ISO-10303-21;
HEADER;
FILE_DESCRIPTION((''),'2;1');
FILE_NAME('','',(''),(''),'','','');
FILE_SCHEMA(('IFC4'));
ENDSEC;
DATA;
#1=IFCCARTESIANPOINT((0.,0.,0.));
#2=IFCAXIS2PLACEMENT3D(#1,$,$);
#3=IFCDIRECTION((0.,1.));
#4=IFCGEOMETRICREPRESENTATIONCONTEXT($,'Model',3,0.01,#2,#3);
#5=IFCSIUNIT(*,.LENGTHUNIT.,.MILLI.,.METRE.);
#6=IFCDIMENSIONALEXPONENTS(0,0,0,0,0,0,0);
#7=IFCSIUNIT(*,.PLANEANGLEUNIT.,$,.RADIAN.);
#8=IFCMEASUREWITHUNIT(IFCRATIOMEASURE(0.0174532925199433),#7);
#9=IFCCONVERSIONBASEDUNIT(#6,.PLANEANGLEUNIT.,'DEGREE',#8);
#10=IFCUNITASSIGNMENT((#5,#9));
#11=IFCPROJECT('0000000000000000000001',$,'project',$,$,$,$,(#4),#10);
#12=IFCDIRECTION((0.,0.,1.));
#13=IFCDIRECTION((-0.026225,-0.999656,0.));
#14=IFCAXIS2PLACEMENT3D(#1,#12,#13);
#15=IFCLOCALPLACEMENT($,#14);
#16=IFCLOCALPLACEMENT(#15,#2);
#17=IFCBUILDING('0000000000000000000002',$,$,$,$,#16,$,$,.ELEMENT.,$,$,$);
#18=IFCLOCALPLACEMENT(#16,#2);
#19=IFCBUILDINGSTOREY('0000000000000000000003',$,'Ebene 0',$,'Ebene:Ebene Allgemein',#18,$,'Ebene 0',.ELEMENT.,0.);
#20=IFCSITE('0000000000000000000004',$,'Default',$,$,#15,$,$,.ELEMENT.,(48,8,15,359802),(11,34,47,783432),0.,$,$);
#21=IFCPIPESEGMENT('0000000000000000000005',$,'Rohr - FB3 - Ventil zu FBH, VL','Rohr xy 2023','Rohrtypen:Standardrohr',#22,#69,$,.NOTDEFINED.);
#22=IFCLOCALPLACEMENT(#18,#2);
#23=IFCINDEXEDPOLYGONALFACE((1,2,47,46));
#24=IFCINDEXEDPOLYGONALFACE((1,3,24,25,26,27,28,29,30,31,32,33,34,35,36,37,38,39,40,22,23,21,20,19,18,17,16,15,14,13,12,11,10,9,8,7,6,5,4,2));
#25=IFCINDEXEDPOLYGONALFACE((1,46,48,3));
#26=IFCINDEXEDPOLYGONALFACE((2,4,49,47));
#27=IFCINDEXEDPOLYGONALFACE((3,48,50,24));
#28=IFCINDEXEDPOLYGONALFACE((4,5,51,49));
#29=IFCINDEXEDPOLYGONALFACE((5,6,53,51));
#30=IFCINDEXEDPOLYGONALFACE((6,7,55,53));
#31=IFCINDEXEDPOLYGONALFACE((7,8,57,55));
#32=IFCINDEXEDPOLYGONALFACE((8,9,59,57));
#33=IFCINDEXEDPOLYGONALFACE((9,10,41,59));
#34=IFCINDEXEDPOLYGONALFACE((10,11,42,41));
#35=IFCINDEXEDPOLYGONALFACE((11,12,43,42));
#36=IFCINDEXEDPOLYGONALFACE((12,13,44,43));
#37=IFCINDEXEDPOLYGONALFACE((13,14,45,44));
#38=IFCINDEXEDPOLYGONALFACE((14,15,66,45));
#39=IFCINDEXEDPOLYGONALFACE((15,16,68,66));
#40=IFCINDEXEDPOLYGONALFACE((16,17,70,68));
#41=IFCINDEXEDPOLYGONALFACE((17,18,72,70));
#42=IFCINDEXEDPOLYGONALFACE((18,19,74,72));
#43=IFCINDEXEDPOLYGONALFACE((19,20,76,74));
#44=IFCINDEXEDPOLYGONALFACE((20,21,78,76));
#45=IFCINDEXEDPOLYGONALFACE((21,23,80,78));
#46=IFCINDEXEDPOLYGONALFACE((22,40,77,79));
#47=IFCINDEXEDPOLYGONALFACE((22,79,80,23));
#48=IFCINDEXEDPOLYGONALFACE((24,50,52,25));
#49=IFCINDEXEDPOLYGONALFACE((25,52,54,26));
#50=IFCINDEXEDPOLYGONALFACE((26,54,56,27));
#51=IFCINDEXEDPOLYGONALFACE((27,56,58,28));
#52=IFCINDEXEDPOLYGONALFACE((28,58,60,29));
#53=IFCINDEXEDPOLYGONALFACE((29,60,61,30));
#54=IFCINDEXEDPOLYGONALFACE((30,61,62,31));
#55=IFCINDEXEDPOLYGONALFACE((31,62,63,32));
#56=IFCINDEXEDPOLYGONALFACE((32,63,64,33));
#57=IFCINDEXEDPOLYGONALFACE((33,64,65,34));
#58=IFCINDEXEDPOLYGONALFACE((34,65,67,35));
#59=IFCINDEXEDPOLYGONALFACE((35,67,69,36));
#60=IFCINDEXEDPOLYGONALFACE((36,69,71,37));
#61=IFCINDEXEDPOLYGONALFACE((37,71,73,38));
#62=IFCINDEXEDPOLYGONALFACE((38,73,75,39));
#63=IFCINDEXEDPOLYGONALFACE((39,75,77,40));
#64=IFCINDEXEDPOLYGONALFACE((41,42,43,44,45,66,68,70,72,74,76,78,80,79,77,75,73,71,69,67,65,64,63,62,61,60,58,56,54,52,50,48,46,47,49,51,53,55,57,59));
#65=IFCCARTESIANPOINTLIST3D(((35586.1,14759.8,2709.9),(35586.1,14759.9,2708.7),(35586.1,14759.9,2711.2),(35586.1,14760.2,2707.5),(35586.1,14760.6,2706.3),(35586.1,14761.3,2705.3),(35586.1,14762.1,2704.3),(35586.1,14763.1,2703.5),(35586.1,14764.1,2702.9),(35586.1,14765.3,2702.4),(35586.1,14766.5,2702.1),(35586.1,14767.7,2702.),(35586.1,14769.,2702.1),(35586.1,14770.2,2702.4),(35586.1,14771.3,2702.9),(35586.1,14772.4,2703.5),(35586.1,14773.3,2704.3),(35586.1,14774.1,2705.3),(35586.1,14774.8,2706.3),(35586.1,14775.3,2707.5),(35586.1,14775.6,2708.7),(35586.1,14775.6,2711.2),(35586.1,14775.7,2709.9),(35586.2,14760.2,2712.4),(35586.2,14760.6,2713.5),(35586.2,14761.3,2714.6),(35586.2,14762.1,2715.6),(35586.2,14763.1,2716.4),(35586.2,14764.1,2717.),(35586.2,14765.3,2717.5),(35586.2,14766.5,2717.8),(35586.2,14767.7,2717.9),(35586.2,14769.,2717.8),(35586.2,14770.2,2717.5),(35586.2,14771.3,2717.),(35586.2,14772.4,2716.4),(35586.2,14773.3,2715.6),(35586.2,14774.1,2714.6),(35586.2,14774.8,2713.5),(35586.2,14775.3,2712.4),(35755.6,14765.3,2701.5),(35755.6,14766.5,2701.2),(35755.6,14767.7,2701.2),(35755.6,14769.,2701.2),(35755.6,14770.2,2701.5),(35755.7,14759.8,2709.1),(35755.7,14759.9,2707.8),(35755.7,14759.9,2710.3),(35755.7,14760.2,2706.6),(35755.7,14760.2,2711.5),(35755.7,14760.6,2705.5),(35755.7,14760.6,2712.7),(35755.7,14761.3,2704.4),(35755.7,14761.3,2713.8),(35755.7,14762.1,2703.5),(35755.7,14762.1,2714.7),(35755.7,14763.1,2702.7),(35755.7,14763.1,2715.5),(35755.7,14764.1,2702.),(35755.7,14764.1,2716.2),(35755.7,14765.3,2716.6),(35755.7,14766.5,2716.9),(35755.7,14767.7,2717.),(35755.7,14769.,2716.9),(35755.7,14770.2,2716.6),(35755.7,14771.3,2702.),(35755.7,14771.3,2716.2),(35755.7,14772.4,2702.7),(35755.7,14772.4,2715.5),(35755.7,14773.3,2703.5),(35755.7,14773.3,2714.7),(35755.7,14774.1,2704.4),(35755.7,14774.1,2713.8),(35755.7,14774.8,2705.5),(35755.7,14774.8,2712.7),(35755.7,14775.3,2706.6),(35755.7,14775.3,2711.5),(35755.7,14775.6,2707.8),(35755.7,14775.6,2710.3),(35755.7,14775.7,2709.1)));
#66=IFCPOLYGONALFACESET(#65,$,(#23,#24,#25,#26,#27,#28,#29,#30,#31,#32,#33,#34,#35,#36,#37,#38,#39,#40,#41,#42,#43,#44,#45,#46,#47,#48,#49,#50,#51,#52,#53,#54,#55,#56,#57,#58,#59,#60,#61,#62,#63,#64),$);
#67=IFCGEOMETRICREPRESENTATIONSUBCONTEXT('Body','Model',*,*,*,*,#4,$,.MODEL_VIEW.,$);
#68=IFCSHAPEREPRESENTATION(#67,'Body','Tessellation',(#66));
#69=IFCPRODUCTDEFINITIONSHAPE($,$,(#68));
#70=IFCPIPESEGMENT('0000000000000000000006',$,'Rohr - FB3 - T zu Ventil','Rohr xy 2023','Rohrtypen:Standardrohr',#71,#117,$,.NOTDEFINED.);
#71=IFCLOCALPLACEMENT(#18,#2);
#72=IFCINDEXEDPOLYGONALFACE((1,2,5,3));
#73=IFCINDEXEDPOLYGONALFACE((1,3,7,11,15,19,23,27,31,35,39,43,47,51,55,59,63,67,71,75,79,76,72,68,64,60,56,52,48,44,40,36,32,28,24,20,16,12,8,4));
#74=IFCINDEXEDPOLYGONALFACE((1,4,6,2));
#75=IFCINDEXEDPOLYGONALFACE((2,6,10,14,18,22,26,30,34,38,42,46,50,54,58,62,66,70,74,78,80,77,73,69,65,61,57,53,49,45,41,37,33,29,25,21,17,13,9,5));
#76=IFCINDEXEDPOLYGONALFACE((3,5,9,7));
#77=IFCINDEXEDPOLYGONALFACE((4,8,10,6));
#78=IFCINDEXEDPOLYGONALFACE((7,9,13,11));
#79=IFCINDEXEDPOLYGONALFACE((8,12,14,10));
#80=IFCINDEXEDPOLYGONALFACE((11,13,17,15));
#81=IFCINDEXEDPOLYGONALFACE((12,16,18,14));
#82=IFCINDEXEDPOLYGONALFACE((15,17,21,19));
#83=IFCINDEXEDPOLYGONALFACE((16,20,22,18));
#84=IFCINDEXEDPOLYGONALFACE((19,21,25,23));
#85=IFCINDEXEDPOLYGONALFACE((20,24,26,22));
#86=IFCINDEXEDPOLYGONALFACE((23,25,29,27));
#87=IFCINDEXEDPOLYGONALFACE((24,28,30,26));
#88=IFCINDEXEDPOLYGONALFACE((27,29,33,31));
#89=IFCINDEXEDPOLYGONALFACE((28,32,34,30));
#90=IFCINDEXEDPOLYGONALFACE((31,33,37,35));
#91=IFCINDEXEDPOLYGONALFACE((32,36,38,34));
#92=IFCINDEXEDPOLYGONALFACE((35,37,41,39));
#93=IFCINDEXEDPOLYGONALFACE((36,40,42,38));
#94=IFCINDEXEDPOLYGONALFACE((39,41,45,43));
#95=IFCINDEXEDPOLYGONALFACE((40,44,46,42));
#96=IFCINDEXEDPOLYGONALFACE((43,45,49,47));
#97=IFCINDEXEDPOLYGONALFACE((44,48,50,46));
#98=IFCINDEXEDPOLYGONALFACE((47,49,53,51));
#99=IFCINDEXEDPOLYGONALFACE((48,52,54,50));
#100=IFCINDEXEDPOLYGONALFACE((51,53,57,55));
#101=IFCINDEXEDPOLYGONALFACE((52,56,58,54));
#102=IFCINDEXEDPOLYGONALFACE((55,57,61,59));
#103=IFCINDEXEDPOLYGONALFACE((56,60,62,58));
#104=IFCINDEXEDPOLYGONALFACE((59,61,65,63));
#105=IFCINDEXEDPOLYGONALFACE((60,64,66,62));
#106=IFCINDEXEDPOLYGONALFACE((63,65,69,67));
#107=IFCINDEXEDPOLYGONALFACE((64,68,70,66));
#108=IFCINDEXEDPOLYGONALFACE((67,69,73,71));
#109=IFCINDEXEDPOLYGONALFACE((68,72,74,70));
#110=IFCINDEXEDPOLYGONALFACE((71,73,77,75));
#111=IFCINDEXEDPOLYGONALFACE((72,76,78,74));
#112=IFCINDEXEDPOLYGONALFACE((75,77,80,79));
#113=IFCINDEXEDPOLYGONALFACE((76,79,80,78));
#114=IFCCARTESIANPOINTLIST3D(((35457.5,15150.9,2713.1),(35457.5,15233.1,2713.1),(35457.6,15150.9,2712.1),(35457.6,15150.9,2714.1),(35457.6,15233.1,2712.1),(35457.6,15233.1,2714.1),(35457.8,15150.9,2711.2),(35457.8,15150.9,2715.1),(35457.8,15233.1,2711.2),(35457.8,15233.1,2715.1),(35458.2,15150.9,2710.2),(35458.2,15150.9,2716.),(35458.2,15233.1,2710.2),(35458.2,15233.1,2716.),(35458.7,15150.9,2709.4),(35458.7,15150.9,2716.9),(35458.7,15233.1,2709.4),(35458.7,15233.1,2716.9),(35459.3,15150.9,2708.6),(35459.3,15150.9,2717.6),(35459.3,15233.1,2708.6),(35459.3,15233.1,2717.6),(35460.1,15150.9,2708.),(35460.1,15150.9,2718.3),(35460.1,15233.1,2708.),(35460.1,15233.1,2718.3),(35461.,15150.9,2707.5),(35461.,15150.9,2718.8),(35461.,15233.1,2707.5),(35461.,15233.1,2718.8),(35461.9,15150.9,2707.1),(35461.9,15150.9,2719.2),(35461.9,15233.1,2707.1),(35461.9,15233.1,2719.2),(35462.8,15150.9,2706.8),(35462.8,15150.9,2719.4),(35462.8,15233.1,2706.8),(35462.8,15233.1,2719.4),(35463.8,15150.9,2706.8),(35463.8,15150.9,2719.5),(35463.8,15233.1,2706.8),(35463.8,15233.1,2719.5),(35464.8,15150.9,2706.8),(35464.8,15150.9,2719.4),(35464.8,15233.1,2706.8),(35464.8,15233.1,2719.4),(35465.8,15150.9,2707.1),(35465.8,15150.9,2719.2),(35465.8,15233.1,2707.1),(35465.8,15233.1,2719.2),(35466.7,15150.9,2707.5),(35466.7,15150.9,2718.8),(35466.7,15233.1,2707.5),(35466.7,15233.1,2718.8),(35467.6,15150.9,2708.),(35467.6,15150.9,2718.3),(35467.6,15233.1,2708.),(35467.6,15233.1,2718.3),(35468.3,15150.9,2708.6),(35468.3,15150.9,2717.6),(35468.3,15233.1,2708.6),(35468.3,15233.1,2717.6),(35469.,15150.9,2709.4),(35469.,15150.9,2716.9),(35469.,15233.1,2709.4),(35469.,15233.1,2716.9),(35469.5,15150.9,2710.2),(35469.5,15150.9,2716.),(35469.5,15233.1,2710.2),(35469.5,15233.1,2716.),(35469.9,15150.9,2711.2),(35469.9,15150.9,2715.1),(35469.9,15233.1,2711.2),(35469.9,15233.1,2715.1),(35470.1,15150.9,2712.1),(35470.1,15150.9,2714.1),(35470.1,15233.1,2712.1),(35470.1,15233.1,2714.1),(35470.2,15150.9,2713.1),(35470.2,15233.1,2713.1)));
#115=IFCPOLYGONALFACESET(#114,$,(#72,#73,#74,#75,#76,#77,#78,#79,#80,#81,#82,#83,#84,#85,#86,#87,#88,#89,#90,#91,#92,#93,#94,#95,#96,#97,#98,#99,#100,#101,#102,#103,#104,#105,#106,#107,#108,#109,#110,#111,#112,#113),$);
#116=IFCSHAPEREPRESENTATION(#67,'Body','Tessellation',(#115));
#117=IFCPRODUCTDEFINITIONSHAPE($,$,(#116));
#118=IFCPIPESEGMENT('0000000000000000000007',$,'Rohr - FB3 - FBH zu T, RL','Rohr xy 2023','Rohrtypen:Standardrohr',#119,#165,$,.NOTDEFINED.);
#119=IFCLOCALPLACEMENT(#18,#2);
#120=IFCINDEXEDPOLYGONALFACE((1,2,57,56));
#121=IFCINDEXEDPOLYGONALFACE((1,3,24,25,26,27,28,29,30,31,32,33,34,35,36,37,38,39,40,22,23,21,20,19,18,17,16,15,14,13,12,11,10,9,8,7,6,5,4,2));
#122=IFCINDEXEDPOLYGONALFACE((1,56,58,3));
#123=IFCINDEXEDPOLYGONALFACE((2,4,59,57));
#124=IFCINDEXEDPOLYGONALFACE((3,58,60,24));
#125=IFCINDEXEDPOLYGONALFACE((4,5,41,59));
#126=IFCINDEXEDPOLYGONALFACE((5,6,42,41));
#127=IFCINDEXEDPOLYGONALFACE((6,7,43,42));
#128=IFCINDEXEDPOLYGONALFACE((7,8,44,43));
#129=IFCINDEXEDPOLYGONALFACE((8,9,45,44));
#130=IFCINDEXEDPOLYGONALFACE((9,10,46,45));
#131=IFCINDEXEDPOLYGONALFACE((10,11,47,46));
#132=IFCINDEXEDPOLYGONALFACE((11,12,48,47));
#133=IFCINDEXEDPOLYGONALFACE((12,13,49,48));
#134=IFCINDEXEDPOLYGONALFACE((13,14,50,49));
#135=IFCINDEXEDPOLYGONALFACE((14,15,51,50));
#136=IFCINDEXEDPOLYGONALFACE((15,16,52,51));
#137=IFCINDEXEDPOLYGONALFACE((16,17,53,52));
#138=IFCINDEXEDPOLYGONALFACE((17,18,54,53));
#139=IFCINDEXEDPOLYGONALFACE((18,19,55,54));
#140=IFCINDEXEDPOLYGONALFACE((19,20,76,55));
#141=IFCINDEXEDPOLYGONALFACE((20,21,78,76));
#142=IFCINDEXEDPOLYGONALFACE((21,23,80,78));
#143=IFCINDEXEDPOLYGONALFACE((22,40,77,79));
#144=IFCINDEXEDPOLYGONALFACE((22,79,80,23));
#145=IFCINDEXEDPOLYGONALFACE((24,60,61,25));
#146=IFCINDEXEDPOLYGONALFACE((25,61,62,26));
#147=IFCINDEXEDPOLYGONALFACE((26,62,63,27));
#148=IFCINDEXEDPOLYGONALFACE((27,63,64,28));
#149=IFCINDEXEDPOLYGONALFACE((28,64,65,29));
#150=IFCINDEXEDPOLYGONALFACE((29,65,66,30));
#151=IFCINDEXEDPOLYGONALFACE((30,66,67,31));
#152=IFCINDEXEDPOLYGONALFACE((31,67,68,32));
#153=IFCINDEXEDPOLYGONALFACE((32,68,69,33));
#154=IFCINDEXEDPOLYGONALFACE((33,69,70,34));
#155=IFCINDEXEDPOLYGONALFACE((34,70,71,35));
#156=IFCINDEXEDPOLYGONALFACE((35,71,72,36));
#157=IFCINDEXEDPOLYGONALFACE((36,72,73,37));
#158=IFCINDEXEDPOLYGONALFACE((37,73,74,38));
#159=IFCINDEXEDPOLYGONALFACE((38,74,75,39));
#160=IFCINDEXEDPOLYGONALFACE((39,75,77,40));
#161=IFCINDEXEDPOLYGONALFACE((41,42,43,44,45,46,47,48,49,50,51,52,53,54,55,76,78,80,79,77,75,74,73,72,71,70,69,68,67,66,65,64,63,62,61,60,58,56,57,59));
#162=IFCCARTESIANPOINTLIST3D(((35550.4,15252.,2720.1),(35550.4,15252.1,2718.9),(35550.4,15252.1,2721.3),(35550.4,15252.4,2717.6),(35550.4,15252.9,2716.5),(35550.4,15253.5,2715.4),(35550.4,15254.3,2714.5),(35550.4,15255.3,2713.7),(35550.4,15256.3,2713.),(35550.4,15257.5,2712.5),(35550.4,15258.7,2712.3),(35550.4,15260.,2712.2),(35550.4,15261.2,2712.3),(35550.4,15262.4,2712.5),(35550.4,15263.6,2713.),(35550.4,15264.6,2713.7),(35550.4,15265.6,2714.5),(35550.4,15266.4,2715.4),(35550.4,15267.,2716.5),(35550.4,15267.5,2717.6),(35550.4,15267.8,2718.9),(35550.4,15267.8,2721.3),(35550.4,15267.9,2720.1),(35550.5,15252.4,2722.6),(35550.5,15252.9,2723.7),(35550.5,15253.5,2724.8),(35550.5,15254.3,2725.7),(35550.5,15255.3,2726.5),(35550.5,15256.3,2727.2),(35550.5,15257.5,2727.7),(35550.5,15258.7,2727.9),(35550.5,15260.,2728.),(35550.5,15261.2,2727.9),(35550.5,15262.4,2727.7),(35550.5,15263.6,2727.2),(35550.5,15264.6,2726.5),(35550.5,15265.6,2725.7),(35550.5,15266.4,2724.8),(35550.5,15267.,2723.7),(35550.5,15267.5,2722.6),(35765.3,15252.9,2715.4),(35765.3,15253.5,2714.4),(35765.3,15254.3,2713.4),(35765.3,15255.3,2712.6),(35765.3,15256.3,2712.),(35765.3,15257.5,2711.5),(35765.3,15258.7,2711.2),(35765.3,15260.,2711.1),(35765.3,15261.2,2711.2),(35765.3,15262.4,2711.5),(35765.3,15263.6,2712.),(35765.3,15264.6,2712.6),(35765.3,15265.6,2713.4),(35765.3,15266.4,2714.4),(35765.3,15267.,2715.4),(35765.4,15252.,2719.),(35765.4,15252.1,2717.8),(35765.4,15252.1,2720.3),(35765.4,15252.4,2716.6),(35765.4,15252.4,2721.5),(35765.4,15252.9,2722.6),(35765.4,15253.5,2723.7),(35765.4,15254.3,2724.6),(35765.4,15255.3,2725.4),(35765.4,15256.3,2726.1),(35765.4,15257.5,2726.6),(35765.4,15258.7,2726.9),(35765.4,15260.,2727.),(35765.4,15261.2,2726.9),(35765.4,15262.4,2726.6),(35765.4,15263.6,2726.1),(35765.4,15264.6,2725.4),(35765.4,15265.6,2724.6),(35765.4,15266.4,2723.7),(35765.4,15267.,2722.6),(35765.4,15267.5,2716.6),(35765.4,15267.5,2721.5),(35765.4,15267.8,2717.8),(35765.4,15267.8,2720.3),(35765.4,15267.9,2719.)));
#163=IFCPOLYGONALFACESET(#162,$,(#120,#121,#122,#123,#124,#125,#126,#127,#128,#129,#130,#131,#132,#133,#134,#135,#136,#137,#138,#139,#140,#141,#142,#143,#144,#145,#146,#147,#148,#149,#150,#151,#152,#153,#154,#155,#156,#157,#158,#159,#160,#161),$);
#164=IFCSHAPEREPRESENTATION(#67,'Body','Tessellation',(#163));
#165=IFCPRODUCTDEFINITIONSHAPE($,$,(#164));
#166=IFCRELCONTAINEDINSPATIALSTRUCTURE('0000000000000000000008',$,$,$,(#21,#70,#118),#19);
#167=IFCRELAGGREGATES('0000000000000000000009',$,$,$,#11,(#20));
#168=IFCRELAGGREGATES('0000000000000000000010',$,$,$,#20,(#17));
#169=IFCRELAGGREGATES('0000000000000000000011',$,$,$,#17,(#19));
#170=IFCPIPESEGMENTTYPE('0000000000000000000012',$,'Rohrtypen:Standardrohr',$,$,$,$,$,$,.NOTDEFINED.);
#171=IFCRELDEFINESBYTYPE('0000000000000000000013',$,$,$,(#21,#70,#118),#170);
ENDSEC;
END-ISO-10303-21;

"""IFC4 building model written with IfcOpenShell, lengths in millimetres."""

from ifc_helpers import new_model, entity, si_unit, converted_unit, direction, frame, origin, place, context, subcontext, project, spatial, indexed_curve, outline, extrude, type_object, element, save


model = new_model("IFC4")

# Units and contexts
model_context = context("Model", 3, precision=0.01, world=origin(), true_north=direction((0.0, 1.0)))
body_context = subcontext(model_context, "Body", "Model", "MODEL_VIEW")
ifc_project = project(units=[si_unit("LENGTHUNIT", "METRE", prefix="MILLI"), converted_unit("PLANEANGLEUNIT", "DEGREE", entity("IfcRatioMeasure", 0.0174532925199433), si_unit("PLANEANGLEUNIT", "RADIAN"), dimensions=[0, 0, 0, 0, 0, 0, 0])], contexts=[model_context])

# Site, building, storey
site_placement = place(None, frame((0.0, 0.0, 0.0), z_axis=(0.0, 0.0, 1.0), x_axis=(-0.026225, -0.999656, 0.0)))
site = spatial("IfcSite", under=ifc_project, at=site_placement, Name="Default", CompositionType="ELEMENT", RefLatitude=(48, 8, 15, 359802), RefLongitude=(11, 34, 47, 783432), RefElevation=0.0)
building_placement = place(site_placement, origin())
building = spatial("IfcBuilding", under=site, at=building_placement, CompositionType="ELEMENT")
storey_placement = place(building_placement, origin())
storey = spatial("IfcBuildingStorey", under=building, at=storey_placement, Name="Ebene 0", ObjectType="Ebene:Ebene Allgemein", LongName="Ebene 0", CompositionType="ELEMENT", Elevation=0.0)

# Pipe segments
pipe_segment_type = type_object("IfcPipeSegmentType", Name="Rohrtypen:Standardrohr", PredefinedType="NOTDEFINED")
pipe_segment_1_placement = place(storey_placement, origin())
element("IfcPipeSegment", 1, at=pipe_segment_1_placement, inside=storey, type_object=pipe_segment_type, Name="Rohr - FB3 - Ventil zu FBH, VL", Description="Rohr xy 2023", ObjectType="Rohrtypen:Standardrohr", PredefinedType="NOTDEFINED", context=body_context, shape_type="SweptSolid", body=[
    extrude(outline(indexed_curve([(7.9, 0.0), (7.8, 1.2), (7.6, 2.5), (7.1, 3.6), (6.4, 4.7), (5.6, 5.6), (4.7, 6.4), (3.6, 7.1), (2.5, 7.6), (1.2, 7.8), (0.0, 7.9), (-1.2, 7.8), (-2.5, 7.6), (-3.6, 7.1), (-4.7, 6.4), (-5.6, 5.6), (-6.4, 4.7), (-7.1, 3.6), (-7.6, 2.5), (-7.8, 1.2), (-7.9, 0.0), (-7.8, -1.2), (-7.6, -2.5), (-7.1, -3.6), (-6.4, -4.7), (-5.6, -5.6), (-4.7, -6.4), (-3.6, -7.1), (-2.5, -7.6), (-1.2, -7.8), (0.0, -7.9), (1.2, -7.8), (2.5, -7.6), (3.6, -7.1), (4.7, -6.4), (5.6, -5.6), (6.4, -4.7), (7.1, -3.6), (7.6, -2.5), (7.8, -1.2), (7.9, 0.0)], self_intersect=False)), frame((35586.1, 14767.7, 2709.9), z_axis=(0.999988, 0.0, -0.005), x_axis=(0.0, 1.0, 0.0)), (0.0, 0.0, 1.0), 169.5),
])
pipe_segment_2_placement = place(storey_placement, origin())
element("IfcPipeSegment", 2, at=pipe_segment_2_placement, inside=storey, type_object=pipe_segment_type, Name="Rohr - FB3 - T zu Ventil", Description="Rohr xy 2023", ObjectType="Rohrtypen:Standardrohr", PredefinedType="NOTDEFINED", context=body_context, shape_type="SweptSolid", body=[
    extrude(outline(indexed_curve([(6.3, 0.0), (6.3, 1.0), (6.0, 2.0), (5.7, 2.9), (5.1, 3.7), (4.5, 4.5), (3.7, 5.1), (2.9, 5.7), (2.0, 6.0), (1.0, 6.3), (0.0, 6.4), (-1.0, 6.3), (-2.0, 6.0), (-2.9, 5.7), (-3.7, 5.1), (-4.5, 4.5), (-5.1, 3.7), (-5.7, 2.9), (-6.0, 2.0), (-6.3, 1.0), (-6.3, 0.0), (-6.3, -1.0), (-6.0, -2.0), (-5.7, -2.9), (-5.1, -3.7), (-4.5, -4.5), (-3.7, -5.1), (-2.9, -5.7), (-2.0, -6.0), (-1.0, -6.3), (0.0, -6.4), (1.0, -6.3), (2.0, -6.0), (2.9, -5.7), (3.7, -5.1), (4.5, -4.5), (5.1, -3.7), (5.7, -2.9), (6.0, -2.0), (6.3, -1.0), (6.3, 0.0)], self_intersect=False)), frame((35463.8, 15150.9, 2713.1), z_axis=(0.0, 1.0, 0.0), x_axis=(-1.0, 0.0, 0.0)), (0.0, 0.0, 1.0), 82.2),
])
pipe_segment_3_placement = place(storey_placement, origin())
element("IfcPipeSegment", 3, at=pipe_segment_3_placement, inside=storey, type_object=pipe_segment_type, Name="Rohr - FB3 - FBH zu T, RL", Description="Rohr xy 2023", ObjectType="Rohrtypen:Standardrohr", PredefinedType="NOTDEFINED", context=body_context, shape_type="SweptSolid", body=[
    extrude(outline(indexed_curve([(7.9, 0.0), (7.8, 1.2), (7.6, 2.5), (7.1, 3.6), (6.4, 4.7), (5.6, 5.6), (4.7, 6.4), (3.6, 7.1), (2.5, 7.6), (1.2, 7.8), (0.0, 7.9), (-1.2, 7.8), (-2.5, 7.6), (-3.6, 7.1), (-4.7, 6.4), (-5.6, 5.6), (-6.4, 4.7), (-7.1, 3.6), (-7.6, 2.5), (-7.8, 1.2), (-7.9, 0.0), (-7.8, -1.2), (-7.6, -2.5), (-7.1, -3.6), (-6.4, -4.7), (-5.6, -5.6), (-4.7, -6.4), (-3.6, -7.1), (-2.5, -7.6), (-1.2, -7.8), (0.0, -7.9), (1.2, -7.8), (2.5, -7.6), (3.6, -7.1), (4.7, -6.4), (5.6, -5.6), (6.4, -4.7), (7.1, -3.6), (7.6, -2.5), (7.8, -1.2), (7.9, 0.0)], self_intersect=False)), frame((35765.4, 15260.0, 2719.0), z_axis=(-0.999988, 0.0, 0.005), x_axis=(0.0, 1.0, 0.0)), (0.0, 0.0, 1.0), 214.9),
])

save(model, "model.ifc")
